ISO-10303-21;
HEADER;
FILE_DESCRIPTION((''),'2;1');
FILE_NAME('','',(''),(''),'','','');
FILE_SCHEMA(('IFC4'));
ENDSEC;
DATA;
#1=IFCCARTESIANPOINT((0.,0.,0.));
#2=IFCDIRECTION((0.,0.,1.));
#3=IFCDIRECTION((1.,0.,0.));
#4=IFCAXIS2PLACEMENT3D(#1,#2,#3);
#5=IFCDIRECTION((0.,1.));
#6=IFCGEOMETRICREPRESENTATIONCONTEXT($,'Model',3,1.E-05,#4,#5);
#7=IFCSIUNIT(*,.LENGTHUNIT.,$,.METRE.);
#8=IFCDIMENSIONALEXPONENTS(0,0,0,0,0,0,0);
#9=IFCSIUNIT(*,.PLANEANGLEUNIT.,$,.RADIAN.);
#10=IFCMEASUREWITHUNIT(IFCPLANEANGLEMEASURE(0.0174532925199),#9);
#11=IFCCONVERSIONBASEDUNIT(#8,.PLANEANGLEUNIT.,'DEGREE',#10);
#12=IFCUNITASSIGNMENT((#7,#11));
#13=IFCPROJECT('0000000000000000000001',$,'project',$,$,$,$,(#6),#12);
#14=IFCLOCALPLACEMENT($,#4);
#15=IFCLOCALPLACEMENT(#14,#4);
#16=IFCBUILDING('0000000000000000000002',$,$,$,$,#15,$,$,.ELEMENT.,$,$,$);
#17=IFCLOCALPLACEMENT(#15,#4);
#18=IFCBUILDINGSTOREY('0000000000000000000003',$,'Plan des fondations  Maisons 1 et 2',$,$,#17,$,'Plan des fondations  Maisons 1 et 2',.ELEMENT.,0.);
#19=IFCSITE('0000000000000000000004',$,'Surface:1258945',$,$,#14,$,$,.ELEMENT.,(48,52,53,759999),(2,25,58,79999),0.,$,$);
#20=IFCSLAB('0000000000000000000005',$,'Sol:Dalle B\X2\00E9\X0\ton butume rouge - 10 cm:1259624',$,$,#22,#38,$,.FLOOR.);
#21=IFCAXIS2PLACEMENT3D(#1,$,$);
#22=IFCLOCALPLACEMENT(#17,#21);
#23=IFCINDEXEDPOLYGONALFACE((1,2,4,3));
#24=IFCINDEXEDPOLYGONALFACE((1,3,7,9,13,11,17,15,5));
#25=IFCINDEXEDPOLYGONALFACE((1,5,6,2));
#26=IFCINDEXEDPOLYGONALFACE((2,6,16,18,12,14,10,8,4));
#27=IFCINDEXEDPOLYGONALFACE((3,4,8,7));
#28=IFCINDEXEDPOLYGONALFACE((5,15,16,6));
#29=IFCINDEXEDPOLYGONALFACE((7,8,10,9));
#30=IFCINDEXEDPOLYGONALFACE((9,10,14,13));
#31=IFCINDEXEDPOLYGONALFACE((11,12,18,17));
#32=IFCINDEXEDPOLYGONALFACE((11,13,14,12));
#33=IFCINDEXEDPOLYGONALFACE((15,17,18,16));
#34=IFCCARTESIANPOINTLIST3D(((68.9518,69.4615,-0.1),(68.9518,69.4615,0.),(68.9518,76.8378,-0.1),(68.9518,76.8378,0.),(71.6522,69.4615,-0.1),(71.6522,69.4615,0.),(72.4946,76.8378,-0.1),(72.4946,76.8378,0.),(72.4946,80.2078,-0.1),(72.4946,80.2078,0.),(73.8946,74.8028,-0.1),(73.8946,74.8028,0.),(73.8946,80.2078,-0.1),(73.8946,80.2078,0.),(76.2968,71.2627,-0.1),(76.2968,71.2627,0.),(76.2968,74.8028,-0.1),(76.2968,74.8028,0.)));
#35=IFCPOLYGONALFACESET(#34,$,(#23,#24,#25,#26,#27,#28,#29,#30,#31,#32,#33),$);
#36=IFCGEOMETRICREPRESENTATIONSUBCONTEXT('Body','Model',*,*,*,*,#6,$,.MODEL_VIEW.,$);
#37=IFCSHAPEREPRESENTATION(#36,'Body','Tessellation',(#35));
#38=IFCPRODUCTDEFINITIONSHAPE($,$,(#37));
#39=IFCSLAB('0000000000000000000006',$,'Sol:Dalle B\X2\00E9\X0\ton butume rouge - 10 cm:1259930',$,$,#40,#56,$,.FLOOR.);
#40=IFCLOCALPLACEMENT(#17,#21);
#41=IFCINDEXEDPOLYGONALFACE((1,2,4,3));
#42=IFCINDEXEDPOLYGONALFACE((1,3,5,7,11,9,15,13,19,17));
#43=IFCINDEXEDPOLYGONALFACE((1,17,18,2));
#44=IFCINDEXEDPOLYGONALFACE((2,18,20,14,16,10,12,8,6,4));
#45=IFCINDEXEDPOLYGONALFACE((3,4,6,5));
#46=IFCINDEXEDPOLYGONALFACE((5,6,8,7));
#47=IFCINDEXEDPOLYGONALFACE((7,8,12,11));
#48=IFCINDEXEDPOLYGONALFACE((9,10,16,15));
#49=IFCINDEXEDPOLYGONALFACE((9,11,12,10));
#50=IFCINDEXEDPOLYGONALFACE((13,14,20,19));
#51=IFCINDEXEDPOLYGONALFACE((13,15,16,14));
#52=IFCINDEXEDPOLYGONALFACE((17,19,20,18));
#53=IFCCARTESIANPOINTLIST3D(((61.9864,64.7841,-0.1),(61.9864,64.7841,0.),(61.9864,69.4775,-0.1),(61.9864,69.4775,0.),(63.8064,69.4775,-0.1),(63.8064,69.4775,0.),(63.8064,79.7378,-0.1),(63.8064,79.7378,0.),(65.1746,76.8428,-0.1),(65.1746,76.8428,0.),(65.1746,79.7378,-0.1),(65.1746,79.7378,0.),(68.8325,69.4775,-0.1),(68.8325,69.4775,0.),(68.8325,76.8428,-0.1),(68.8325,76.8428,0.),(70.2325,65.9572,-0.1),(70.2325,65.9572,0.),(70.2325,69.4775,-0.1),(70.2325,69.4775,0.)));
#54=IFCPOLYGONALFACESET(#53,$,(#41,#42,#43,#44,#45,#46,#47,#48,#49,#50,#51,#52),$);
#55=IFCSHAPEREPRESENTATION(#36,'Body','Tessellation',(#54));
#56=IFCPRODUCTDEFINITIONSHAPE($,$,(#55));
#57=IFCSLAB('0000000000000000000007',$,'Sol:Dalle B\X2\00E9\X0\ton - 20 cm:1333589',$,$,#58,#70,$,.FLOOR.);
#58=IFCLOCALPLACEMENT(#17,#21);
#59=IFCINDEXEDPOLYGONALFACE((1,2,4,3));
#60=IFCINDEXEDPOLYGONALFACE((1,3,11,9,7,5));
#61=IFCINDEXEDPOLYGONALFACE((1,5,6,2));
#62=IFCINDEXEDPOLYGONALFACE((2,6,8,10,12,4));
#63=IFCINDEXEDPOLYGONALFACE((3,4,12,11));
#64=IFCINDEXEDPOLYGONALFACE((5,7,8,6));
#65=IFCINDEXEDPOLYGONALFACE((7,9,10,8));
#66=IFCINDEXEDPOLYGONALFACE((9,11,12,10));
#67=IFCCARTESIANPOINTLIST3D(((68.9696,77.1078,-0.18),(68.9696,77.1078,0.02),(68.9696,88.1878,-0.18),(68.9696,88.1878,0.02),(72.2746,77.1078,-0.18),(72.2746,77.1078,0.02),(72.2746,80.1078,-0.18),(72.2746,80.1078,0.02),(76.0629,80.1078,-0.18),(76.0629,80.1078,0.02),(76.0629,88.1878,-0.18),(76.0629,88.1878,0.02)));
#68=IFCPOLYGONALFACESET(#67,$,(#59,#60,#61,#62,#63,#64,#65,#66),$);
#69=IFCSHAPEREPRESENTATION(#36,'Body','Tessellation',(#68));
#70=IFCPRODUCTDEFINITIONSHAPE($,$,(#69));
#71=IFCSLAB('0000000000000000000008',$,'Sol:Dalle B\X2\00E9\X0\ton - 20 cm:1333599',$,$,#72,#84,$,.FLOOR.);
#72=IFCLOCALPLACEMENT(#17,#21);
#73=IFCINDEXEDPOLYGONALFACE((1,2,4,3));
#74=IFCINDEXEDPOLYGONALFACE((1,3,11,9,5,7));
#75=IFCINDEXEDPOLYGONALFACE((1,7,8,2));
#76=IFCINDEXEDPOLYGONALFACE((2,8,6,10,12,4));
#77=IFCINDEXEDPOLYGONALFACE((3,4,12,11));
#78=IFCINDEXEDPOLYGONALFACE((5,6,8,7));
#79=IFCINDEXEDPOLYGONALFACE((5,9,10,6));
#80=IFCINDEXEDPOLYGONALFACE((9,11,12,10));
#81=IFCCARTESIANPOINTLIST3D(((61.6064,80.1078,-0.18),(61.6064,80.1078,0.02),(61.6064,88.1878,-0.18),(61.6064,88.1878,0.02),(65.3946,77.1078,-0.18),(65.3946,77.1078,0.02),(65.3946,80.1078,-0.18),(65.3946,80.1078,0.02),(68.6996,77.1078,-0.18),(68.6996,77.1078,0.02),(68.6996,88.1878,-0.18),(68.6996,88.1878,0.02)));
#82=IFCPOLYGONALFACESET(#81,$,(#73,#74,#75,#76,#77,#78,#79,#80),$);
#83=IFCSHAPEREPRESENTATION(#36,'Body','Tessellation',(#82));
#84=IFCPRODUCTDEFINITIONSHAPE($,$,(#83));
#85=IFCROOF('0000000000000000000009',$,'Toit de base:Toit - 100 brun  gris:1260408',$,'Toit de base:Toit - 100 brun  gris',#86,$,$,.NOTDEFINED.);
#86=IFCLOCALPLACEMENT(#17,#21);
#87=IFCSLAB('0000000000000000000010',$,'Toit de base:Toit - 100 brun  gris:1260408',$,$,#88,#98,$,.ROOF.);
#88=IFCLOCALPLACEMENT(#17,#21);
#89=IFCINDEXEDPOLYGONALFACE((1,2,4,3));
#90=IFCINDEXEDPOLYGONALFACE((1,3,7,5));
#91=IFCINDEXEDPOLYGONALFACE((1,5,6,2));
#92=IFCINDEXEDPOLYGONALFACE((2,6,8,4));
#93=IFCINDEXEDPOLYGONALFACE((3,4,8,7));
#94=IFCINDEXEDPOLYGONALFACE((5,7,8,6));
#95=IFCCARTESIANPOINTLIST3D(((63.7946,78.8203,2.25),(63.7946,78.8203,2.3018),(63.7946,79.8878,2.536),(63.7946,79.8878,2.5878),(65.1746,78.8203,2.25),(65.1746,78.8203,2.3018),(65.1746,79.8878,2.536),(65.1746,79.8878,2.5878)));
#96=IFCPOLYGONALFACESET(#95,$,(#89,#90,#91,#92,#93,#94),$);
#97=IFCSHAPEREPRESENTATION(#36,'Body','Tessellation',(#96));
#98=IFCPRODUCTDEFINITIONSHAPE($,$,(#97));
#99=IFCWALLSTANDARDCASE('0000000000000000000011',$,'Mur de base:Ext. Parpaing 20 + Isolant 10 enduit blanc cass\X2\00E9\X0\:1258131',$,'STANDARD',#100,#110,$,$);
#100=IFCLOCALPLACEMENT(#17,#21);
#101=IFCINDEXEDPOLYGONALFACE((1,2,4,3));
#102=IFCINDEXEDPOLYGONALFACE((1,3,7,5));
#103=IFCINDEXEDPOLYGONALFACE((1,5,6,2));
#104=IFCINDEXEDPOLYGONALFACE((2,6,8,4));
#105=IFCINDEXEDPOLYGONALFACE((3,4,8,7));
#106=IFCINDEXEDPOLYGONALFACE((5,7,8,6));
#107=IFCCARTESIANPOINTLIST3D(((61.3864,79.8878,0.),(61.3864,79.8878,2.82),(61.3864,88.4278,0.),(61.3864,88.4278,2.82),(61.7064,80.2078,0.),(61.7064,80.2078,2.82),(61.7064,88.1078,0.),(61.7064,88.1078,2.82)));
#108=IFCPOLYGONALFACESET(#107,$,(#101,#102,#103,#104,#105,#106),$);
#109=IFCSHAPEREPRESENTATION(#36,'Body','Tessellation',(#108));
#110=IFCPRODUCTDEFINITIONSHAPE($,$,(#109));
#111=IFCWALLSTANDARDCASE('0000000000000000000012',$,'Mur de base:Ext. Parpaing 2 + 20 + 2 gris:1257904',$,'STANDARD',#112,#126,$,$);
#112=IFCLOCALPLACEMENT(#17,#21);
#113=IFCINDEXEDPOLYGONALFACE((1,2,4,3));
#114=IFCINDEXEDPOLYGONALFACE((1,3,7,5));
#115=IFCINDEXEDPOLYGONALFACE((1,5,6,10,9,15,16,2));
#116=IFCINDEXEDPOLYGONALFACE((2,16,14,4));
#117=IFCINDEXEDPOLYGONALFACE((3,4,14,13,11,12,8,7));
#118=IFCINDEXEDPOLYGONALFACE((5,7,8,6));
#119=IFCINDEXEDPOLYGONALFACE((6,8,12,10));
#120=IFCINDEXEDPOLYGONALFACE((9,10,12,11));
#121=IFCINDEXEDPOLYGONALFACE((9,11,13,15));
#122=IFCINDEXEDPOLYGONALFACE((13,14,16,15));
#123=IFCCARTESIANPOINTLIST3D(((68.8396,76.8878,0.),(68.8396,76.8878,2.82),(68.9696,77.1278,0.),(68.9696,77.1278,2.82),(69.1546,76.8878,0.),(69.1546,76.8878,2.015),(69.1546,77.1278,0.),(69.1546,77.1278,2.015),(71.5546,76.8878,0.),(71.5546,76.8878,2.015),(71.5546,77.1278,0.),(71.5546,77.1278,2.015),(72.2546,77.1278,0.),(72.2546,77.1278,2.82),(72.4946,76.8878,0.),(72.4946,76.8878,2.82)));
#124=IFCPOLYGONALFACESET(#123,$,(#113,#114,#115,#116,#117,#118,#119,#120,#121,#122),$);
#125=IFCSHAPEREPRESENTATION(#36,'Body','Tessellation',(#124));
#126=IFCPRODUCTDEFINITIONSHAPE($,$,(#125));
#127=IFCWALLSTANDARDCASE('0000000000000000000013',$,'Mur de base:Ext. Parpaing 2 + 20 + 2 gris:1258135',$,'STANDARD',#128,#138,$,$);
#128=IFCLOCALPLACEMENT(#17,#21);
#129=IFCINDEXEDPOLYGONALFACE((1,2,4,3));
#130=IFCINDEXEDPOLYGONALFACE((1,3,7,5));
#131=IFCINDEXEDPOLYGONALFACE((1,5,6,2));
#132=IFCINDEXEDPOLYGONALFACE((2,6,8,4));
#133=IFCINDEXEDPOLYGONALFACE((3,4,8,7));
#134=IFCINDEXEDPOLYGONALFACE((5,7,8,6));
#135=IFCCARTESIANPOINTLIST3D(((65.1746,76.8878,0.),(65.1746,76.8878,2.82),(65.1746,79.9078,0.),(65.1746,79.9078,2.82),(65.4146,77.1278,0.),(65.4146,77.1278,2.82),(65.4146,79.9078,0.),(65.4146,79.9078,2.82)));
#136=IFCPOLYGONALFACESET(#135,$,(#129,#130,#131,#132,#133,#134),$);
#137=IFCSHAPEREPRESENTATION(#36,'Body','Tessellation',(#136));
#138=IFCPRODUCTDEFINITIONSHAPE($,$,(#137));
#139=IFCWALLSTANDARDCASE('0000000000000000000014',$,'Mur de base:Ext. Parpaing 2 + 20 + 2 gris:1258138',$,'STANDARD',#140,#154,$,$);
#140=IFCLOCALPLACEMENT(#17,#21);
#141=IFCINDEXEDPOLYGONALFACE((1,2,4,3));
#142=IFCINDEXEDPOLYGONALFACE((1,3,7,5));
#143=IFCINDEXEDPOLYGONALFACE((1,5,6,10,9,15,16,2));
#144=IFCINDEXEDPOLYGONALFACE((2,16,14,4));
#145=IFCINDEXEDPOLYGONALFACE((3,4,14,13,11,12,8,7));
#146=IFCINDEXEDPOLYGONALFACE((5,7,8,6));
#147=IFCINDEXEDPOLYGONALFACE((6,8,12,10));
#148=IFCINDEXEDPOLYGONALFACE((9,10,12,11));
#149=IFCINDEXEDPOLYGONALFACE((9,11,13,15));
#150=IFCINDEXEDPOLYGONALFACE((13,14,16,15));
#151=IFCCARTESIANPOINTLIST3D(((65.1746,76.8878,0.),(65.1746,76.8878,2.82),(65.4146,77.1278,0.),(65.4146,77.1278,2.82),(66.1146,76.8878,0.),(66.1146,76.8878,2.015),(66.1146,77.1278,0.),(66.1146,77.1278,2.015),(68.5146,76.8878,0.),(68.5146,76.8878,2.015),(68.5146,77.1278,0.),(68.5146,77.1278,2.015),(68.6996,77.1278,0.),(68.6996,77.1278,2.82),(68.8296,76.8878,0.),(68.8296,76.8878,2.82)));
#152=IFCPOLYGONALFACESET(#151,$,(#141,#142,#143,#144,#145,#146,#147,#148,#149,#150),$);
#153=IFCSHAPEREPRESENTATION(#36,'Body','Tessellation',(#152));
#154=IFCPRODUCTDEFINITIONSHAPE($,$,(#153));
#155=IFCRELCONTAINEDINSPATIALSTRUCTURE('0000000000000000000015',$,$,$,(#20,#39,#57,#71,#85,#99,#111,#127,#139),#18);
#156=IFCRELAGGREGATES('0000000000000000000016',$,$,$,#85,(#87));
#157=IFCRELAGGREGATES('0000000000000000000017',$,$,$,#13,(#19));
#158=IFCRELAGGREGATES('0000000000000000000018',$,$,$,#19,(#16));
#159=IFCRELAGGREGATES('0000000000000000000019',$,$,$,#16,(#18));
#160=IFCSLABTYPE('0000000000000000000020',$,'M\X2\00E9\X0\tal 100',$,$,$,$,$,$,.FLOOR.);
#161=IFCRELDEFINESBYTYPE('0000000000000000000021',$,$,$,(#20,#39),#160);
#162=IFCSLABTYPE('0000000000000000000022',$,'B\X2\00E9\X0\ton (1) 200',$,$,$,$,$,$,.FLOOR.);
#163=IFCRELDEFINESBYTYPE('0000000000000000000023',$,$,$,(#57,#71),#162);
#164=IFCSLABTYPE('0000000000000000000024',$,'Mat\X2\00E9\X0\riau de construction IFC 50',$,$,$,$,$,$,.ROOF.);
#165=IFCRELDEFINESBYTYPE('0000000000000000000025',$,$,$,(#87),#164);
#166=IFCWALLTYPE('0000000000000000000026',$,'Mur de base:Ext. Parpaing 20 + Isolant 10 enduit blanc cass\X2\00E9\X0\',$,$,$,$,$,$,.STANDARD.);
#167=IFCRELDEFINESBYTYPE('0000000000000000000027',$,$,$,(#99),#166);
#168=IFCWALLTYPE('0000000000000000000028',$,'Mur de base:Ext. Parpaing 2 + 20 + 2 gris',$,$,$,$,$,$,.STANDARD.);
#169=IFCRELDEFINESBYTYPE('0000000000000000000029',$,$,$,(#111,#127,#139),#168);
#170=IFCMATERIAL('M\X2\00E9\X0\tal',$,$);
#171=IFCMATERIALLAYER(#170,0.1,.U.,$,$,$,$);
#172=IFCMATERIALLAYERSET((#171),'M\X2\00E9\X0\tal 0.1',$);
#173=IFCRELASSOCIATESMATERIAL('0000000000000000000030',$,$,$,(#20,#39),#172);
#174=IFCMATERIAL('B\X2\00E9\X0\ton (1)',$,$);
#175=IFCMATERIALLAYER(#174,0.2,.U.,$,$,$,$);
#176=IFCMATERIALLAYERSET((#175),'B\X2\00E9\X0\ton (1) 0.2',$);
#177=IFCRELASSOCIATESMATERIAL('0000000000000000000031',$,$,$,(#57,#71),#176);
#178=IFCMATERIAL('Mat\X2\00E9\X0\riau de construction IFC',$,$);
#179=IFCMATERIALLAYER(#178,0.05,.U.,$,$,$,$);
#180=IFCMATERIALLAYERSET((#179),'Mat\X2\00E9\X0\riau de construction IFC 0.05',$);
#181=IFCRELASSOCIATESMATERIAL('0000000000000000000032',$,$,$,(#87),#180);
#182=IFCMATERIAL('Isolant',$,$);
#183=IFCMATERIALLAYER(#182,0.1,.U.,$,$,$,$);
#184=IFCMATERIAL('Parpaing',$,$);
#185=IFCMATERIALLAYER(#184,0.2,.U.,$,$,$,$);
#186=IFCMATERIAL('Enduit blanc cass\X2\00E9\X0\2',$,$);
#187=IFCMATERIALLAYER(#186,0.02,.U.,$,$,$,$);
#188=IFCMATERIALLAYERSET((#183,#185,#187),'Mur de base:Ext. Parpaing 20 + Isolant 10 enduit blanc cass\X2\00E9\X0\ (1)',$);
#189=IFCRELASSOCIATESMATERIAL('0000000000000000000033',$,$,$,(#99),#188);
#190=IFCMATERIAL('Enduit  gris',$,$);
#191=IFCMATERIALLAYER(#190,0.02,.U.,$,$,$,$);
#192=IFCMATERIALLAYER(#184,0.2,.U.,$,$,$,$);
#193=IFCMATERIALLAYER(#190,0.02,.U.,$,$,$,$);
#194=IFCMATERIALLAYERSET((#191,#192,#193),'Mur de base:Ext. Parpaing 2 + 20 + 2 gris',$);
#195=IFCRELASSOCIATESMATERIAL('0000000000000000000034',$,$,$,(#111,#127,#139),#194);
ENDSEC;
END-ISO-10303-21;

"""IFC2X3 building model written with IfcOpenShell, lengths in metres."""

from ifc_helpers import new_model, entity, si_unit, converted_unit, direction, frame, origin_with_axes, place, context, subcontext, project, spatial, polyline, outline, extrude, material, layer, layer_set, layer_usage, type_object, element, aggregate, save


model = new_model("IFC2X3")

# Units and contexts
model_context = context("Model", 3, precision=1e-05, world=origin_with_axes(), true_north=direction((0.0, 1.0)))
body_context = subcontext(model_context, "Body", "Model", "MODEL_VIEW")
ifc_project = project(units=[si_unit("LENGTHUNIT", "METRE"), converted_unit("PLANEANGLEUNIT", "DEGREE", entity("IfcPlaneAngleMeasure", 0.0174532925199), si_unit("PLANEANGLEUNIT", "RADIAN"), dimensions=[0, 0, 0, 0, 0, 0, 0])], contexts=[model_context])

# Site, building, storey
site_placement = place(None, origin_with_axes())
site = spatial("IfcSite", under=ifc_project, at=site_placement, Name="Surface:1258945", CompositionType="ELEMENT", RefLatitude=(48, 52, 53, 759999), RefLongitude=(2, 25, 58, 79999), RefElevation=0.0)
building_placement = place(site_placement, origin_with_axes())
building = spatial("IfcBuilding", under=site, at=building_placement, CompositionType="ELEMENT")
storey_placement = place(building_placement, origin_with_axes())
storey = spatial("IfcBuildingStorey", under=building, at=storey_placement, Name="Plan des fondations  Maisons 1 et 2", LongName="Plan des fondations  Maisons 1 et 2", CompositionType="ELEMENT", Elevation=0.0)

# Slabs
ifc_material_1 = material(Name="Métal")
ifc_layer_1 = layer(ifc_material_1, 0.1, ventilated="UNKNOWN")
ifc_layer_set_1 = layer_set([ifc_layer_1], Name="Métal 0.1")
ifc_layer_usage_1 = layer_usage(ifc_layer_set_1, "AXIS3", "NEGATIVE", 0.1)
slab_type_1 = type_object("IfcSlabType", Name="Métal 100", PredefinedType="FLOOR")
slab_1_placement = place(storey_placement, frame((68.9518, 69.4615, 0.0), z_axis=(0.0, 0.0, 1.0), x_axis=(1.0, 0.0, 0.0)))
element("IfcSlab", 1, at=slab_1_placement, inside=storey, type_object=slab_type_1, material=ifc_layer_usage_1, Name="Sol:Dalle Béton butume rouge - 10 cm:1259624", PredefinedType="FLOOR", context=body_context, shape_type="SweptSolid", body=[
    extrude(outline(polyline([(0.0, 0.0), (2.7004, 0.0), (7.345, 1.8012), (7.345, 5.3412), (4.9428, 5.3412), (4.9428, 10.7462), (3.5428, 10.7462), (3.5428, 7.3762), (0.0, 7.3762), (0.0, 0.0)])), frame((0.0, 0.0, -0.1), z_axis=(0.0, 0.0, 1.0), x_axis=(1.0, 0.0, 0.0)), (0.0, 0.0, 1.0), 0.1),
])
ifc_layer_usage_2 = layer_usage(ifc_layer_set_1, "AXIS3", "NEGATIVE", 0.1)
slab_2_placement = place(storey_placement, frame((61.9864, 64.7841, 0.0), z_axis=(0.0, 0.0, 1.0), x_axis=(1.0, 0.0, 0.0)))
element("IfcSlab", 2, at=slab_2_placement, inside=storey, type_object=slab_type_1, material=ifc_layer_usage_2, Name="Sol:Dalle Béton butume rouge - 10 cm:1259930", PredefinedType="FLOOR", context=body_context, shape_type="SweptSolid", body=[
    extrude(outline(polyline([(0.0, 0.0), (8.2461, 1.173), (8.2461, 4.6934), (6.8461, 4.6934), (6.8461, 12.0586), (3.1883, 12.0586), (3.1883, 14.9536), (1.82, 14.9536), (1.82, 4.6934), (0.0, 4.6934), (0.0, 0.0)])), frame((0.0, 0.0, -0.1), z_axis=(0.0, 0.0, 1.0), x_axis=(1.0, 0.0, 0.0)), (0.0, 0.0, 1.0), 0.1),
])
ifc_material_2 = material(Name="Béton (1)")
ifc_layer_2 = layer(ifc_material_2, 0.2, ventilated="UNKNOWN")
ifc_layer_set_2 = layer_set([ifc_layer_2], Name="Béton (1) 0.2")
ifc_layer_usage_3 = layer_usage(ifc_layer_set_2, "AXIS3", "NEGATIVE", 0.2)
slab_type_2 = type_object("IfcSlabType", Name="Béton (1) 200", PredefinedType="FLOOR")
slab_3_placement = place(storey_placement, frame((68.9696, 77.1078, 0.02), z_axis=(0.0, 0.0, 1.0), x_axis=(1.0, 0.0, 0.0)))
element("IfcSlab", 3, at=slab_3_placement, inside=storey, type_object=slab_type_2, material=ifc_layer_usage_3, Name="Sol:Dalle Béton - 20 cm:1333589", PredefinedType="FLOOR", context=body_context, shape_type="SweptSolid", body=[
    extrude(outline(polyline([(0.0, 0.0), (3.305, 0.0), (3.305, 3.0), (7.0933, 3.0), (7.0933, 11.08), (0.0, 11.08), (0.0, 0.0)])), frame((0.0, 0.0, -0.2), z_axis=(0.0, 0.0, 1.0), x_axis=(1.0, 0.0, 0.0)), (0.0, 0.0, 1.0), 0.2),
])
ifc_layer_usage_4 = layer_usage(ifc_layer_set_2, "AXIS3", "NEGATIVE", 0.2)
slab_4_placement = place(storey_placement, frame((61.6064, 80.1078, 0.02), z_axis=(0.0, 0.0, 1.0), x_axis=(1.0, 0.0, 0.0)))
element("IfcSlab", 4, at=slab_4_placement, inside=storey, type_object=slab_type_2, material=ifc_layer_usage_4, Name="Sol:Dalle Béton - 20 cm:1333599", PredefinedType="FLOOR", context=body_context, shape_type="SweptSolid", body=[
    extrude(outline(polyline([(0.0, 0.0), (3.7883, 0.0), (3.7883, -3.0), (7.0933, -3.0), (7.0933, 8.08), (0.0, 8.08), (0.0, 0.0)])), frame((0.0, 0.0, -0.2), z_axis=(0.0, 0.0, 1.0), x_axis=(1.0, 0.0, 0.0)), (0.0, 0.0, 1.0), 0.2),
])

# Roof, slab
roof_placement = place(storey_placement, origin_with_axes())
roof = element("IfcRoof", 5, at=roof_placement, inside=storey, Name="Toit de base:Toit - 100 brun  gris:1260408", ObjectType="Toit de base:Toit - 100 brun  gris", ShapeType="NOTDEFINED")
ifc_material_3 = material(Name="Matériau de construction IFC")
ifc_layer_3 = layer(ifc_material_3, 0.05, ventilated="UNKNOWN")
ifc_layer_set_3 = layer_set([ifc_layer_3], Name="Matériau de construction IFC 0.05")
ifc_layer_usage_5 = layer_usage(ifc_layer_set_3, "AXIS3", "NEGATIVE", 0.05)
slab_type_3 = type_object("IfcSlabType", Name="Matériau de construction IFC 50", PredefinedType="ROOF")
slab_5_placement = place(roof_placement, frame((63.7946, 79.354, 2.393), z_axis=(0.0, 0.0, 1.0), x_axis=(1.0, 0.0, 0.0)))
slab_5 = element("IfcSlab", 6, at=slab_5_placement, type_object=slab_type_3, material=ifc_layer_usage_5, Name="Toit de base:Toit - 100 brun  gris:1260408", PredefinedType="ROOF", context=body_context, shape_type="SweptSolid", body=[
    extrude(outline(polyline([(0.0, -0.5526), (1.38, -0.5526), (1.38, 0.5526), (0.0, 0.5526), (0.0, -0.5526)])), frame((0.0, 0.0, 0.0), z_axis=(0.0, -0.258819, 0.965926), x_axis=(1.0, 0.0, 0.0)), (0.0, 0.258819, 0.965926), 0.0518),
])
aggregate(roof, [slab_5])

# Wall
ifc_material_4 = material(Name="Isolant")
ifc_layer_4 = layer(ifc_material_4, 0.1, ventilated="UNKNOWN")
ifc_material_5 = material(Name="Parpaing")
ifc_layer_5 = layer(ifc_material_5, 0.2, ventilated="UNKNOWN")
ifc_material_6 = material(Name="Enduit blanc cassé2")
ifc_layer_6 = layer(ifc_material_6, 0.02, ventilated="UNKNOWN")
ifc_layer_set_4 = layer_set([ifc_layer_4, ifc_layer_5, ifc_layer_6], Name="Mur de base:Ext. Parpaing 20 + Isolant 10 enduit blanc cassé (1)")
ifc_layer_usage_6 = layer_usage(ifc_layer_set_4, "AXIS2", "POSITIVE", -0.16)
wall_type_1 = type_object("IfcWallType", Name="Mur de base:Ext. Parpaing 20 + Isolant 10 enduit blanc cassé", PredefinedType="STANDARD")
wall_1_placement = place(storey_placement, frame((61.5464, 80.0478, 0.0), z_axis=(0.0, 0.0, 1.0), x_axis=(0.0, 1.0, 0.0)))
element("IfcWallStandardCase", 7, at=wall_1_placement, inside=storey, type_object=wall_type_1, material=ifc_layer_usage_6, Name="Mur de base:Ext. Parpaing 20 + Isolant 10 enduit blanc cassé:1258131", ObjectType="STANDARD", context=body_context, shape_type="SweptSolid", body=[
    extrude(outline(polyline([(0.16, -0.16), (8.06, -0.16), (8.38, 0.16), (-0.16, 0.16), (0.16, -0.16)])), origin_with_axes(), (0.0, 0.0, 1.0), 2.82),
])

# Wall, opening
ifc_material_7 = material(Name="Enduit  gris")
ifc_layer_7 = layer(ifc_material_7, 0.02, ventilated="UNKNOWN")
ifc_layer_8 = layer(ifc_material_5, 0.2, ventilated="UNKNOWN")
ifc_layer_9 = layer(ifc_material_7, 0.02, ventilated="UNKNOWN")
ifc_layer_set_5 = layer_set([ifc_layer_7, ifc_layer_8, ifc_layer_9], Name="Mur de base:Ext. Parpaing 2 + 20 + 2 gris")
ifc_layer_usage_7 = layer_usage(ifc_layer_set_5, "AXIS2", "POSITIVE", -0.12)
wall_type_2 = type_object("IfcWallType", Name="Mur de base:Ext. Parpaing 2 + 20 + 2 gris", PredefinedType="STANDARD")
wall_2_placement = place(storey_placement, frame((68.9046, 77.0078, 0.0), z_axis=(0.0, 0.0, 1.0), x_axis=(1.0, 0.0, 0.0)))
wall_2 = element("IfcWallStandardCase", 8, at=wall_2_placement, inside=storey, type_object=wall_type_2, material=ifc_layer_usage_7, Name="Mur de base:Ext. Parpaing 2 + 20 + 2 gris:1257904", ObjectType="STANDARD", context=body_context, shape_type="SweptSolid", body=[
    extrude(outline(polyline([(-0.065, -0.12), (3.59, -0.12), (3.35, 0.12), (0.065, 0.12), (-0.065, -0.12)])), origin_with_axes(), (0.0, 0.0, 1.0), 2.82),
])
opening_1_placement = place(wall_2_placement, frame((1.45, 0.0, 0.0), z_axis=(0.0, 0.0, 1.0), x_axis=(1.0, 0.0, 0.0)))
element("IfcOpeningElement", 9, at=opening_1_placement, cuts=wall_2, context=body_context, shape_type="SweptSolid", body=[
    extrude(outline(polyline([(-1.2, 2.015), (-1.2, 0.0), (1.2, 0.0), (1.2, 2.015), (-1.2, 2.015)])), frame((0.0, -0.42, 0.0), z_axis=(0.0, 1.0, 0.0), x_axis=(-1.0, 0.0, 0.0)), (0.0, 0.0, 1.0), 0.84),
])

# Wall
ifc_layer_usage_8 = layer_usage(ifc_layer_set_5, "AXIS2", "POSITIVE", -0.12)
wall_3_placement = place(storey_placement, frame((65.2946, 77.0078, 0.0), z_axis=(0.0, 0.0, 1.0), x_axis=(0.0, 1.0, 0.0)))
element("IfcWallStandardCase", 10, at=wall_3_placement, inside=storey, type_object=wall_type_2, material=ifc_layer_usage_8, Name="Mur de base:Ext. Parpaing 2 + 20 + 2 gris:1258135", ObjectType="STANDARD", context=body_context, shape_type="SweptSolid", body=[
    extrude(outline(polyline([(0.12, -0.12), (2.9, -0.12), (2.9, 0.12), (-0.12, 0.12), (0.12, -0.12)])), origin_with_axes(), (0.0, 0.0, 1.0), 2.82),
])

# Wall, opening
ifc_layer_usage_9 = layer_usage(ifc_layer_set_5, "AXIS2", "POSITIVE", -0.12)
wall_4_placement = place(storey_placement, frame((68.7646, 77.0078, 0.0), z_axis=(0.0, 0.0, 1.0), x_axis=(-1.0, 0.0, 0.0)))
wall_4 = element("IfcWallStandardCase", 11, at=wall_4_placement, inside=storey, type_object=wall_type_2, material=ifc_layer_usage_9, Name="Mur de base:Ext. Parpaing 2 + 20 + 2 gris:1258138", ObjectType="STANDARD", context=body_context, shape_type="SweptSolid", body=[
    extrude(outline(polyline([(0.065, -0.12), (3.35, -0.12), (3.59, 0.12), (-0.065, 0.12), (0.065, -0.12)])), origin_with_axes(), (0.0, 0.0, 1.0), 2.82),
])
opening_2_placement = place(wall_4_placement, frame((1.45, 0.0, 0.0), z_axis=(0.0, 0.0, 1.0), x_axis=(1.0, 0.0, 0.0)))
element("IfcOpeningElement", 12, at=opening_2_placement, cuts=wall_4, context=body_context, shape_type="SweptSolid", body=[
    extrude(outline(polyline([(1.2, -2.015), (1.2, 0.0), (-1.2, 0.0), (-1.2, -2.015), (1.2, -2.015)])), frame((0.0, -0.42, 0.0), z_axis=(0.0, 1.0, 0.0), x_axis=(1.0, 0.0, 0.0)), (0.0, 0.0, 1.0), 0.84),
])

save(model, "model.ifc")
